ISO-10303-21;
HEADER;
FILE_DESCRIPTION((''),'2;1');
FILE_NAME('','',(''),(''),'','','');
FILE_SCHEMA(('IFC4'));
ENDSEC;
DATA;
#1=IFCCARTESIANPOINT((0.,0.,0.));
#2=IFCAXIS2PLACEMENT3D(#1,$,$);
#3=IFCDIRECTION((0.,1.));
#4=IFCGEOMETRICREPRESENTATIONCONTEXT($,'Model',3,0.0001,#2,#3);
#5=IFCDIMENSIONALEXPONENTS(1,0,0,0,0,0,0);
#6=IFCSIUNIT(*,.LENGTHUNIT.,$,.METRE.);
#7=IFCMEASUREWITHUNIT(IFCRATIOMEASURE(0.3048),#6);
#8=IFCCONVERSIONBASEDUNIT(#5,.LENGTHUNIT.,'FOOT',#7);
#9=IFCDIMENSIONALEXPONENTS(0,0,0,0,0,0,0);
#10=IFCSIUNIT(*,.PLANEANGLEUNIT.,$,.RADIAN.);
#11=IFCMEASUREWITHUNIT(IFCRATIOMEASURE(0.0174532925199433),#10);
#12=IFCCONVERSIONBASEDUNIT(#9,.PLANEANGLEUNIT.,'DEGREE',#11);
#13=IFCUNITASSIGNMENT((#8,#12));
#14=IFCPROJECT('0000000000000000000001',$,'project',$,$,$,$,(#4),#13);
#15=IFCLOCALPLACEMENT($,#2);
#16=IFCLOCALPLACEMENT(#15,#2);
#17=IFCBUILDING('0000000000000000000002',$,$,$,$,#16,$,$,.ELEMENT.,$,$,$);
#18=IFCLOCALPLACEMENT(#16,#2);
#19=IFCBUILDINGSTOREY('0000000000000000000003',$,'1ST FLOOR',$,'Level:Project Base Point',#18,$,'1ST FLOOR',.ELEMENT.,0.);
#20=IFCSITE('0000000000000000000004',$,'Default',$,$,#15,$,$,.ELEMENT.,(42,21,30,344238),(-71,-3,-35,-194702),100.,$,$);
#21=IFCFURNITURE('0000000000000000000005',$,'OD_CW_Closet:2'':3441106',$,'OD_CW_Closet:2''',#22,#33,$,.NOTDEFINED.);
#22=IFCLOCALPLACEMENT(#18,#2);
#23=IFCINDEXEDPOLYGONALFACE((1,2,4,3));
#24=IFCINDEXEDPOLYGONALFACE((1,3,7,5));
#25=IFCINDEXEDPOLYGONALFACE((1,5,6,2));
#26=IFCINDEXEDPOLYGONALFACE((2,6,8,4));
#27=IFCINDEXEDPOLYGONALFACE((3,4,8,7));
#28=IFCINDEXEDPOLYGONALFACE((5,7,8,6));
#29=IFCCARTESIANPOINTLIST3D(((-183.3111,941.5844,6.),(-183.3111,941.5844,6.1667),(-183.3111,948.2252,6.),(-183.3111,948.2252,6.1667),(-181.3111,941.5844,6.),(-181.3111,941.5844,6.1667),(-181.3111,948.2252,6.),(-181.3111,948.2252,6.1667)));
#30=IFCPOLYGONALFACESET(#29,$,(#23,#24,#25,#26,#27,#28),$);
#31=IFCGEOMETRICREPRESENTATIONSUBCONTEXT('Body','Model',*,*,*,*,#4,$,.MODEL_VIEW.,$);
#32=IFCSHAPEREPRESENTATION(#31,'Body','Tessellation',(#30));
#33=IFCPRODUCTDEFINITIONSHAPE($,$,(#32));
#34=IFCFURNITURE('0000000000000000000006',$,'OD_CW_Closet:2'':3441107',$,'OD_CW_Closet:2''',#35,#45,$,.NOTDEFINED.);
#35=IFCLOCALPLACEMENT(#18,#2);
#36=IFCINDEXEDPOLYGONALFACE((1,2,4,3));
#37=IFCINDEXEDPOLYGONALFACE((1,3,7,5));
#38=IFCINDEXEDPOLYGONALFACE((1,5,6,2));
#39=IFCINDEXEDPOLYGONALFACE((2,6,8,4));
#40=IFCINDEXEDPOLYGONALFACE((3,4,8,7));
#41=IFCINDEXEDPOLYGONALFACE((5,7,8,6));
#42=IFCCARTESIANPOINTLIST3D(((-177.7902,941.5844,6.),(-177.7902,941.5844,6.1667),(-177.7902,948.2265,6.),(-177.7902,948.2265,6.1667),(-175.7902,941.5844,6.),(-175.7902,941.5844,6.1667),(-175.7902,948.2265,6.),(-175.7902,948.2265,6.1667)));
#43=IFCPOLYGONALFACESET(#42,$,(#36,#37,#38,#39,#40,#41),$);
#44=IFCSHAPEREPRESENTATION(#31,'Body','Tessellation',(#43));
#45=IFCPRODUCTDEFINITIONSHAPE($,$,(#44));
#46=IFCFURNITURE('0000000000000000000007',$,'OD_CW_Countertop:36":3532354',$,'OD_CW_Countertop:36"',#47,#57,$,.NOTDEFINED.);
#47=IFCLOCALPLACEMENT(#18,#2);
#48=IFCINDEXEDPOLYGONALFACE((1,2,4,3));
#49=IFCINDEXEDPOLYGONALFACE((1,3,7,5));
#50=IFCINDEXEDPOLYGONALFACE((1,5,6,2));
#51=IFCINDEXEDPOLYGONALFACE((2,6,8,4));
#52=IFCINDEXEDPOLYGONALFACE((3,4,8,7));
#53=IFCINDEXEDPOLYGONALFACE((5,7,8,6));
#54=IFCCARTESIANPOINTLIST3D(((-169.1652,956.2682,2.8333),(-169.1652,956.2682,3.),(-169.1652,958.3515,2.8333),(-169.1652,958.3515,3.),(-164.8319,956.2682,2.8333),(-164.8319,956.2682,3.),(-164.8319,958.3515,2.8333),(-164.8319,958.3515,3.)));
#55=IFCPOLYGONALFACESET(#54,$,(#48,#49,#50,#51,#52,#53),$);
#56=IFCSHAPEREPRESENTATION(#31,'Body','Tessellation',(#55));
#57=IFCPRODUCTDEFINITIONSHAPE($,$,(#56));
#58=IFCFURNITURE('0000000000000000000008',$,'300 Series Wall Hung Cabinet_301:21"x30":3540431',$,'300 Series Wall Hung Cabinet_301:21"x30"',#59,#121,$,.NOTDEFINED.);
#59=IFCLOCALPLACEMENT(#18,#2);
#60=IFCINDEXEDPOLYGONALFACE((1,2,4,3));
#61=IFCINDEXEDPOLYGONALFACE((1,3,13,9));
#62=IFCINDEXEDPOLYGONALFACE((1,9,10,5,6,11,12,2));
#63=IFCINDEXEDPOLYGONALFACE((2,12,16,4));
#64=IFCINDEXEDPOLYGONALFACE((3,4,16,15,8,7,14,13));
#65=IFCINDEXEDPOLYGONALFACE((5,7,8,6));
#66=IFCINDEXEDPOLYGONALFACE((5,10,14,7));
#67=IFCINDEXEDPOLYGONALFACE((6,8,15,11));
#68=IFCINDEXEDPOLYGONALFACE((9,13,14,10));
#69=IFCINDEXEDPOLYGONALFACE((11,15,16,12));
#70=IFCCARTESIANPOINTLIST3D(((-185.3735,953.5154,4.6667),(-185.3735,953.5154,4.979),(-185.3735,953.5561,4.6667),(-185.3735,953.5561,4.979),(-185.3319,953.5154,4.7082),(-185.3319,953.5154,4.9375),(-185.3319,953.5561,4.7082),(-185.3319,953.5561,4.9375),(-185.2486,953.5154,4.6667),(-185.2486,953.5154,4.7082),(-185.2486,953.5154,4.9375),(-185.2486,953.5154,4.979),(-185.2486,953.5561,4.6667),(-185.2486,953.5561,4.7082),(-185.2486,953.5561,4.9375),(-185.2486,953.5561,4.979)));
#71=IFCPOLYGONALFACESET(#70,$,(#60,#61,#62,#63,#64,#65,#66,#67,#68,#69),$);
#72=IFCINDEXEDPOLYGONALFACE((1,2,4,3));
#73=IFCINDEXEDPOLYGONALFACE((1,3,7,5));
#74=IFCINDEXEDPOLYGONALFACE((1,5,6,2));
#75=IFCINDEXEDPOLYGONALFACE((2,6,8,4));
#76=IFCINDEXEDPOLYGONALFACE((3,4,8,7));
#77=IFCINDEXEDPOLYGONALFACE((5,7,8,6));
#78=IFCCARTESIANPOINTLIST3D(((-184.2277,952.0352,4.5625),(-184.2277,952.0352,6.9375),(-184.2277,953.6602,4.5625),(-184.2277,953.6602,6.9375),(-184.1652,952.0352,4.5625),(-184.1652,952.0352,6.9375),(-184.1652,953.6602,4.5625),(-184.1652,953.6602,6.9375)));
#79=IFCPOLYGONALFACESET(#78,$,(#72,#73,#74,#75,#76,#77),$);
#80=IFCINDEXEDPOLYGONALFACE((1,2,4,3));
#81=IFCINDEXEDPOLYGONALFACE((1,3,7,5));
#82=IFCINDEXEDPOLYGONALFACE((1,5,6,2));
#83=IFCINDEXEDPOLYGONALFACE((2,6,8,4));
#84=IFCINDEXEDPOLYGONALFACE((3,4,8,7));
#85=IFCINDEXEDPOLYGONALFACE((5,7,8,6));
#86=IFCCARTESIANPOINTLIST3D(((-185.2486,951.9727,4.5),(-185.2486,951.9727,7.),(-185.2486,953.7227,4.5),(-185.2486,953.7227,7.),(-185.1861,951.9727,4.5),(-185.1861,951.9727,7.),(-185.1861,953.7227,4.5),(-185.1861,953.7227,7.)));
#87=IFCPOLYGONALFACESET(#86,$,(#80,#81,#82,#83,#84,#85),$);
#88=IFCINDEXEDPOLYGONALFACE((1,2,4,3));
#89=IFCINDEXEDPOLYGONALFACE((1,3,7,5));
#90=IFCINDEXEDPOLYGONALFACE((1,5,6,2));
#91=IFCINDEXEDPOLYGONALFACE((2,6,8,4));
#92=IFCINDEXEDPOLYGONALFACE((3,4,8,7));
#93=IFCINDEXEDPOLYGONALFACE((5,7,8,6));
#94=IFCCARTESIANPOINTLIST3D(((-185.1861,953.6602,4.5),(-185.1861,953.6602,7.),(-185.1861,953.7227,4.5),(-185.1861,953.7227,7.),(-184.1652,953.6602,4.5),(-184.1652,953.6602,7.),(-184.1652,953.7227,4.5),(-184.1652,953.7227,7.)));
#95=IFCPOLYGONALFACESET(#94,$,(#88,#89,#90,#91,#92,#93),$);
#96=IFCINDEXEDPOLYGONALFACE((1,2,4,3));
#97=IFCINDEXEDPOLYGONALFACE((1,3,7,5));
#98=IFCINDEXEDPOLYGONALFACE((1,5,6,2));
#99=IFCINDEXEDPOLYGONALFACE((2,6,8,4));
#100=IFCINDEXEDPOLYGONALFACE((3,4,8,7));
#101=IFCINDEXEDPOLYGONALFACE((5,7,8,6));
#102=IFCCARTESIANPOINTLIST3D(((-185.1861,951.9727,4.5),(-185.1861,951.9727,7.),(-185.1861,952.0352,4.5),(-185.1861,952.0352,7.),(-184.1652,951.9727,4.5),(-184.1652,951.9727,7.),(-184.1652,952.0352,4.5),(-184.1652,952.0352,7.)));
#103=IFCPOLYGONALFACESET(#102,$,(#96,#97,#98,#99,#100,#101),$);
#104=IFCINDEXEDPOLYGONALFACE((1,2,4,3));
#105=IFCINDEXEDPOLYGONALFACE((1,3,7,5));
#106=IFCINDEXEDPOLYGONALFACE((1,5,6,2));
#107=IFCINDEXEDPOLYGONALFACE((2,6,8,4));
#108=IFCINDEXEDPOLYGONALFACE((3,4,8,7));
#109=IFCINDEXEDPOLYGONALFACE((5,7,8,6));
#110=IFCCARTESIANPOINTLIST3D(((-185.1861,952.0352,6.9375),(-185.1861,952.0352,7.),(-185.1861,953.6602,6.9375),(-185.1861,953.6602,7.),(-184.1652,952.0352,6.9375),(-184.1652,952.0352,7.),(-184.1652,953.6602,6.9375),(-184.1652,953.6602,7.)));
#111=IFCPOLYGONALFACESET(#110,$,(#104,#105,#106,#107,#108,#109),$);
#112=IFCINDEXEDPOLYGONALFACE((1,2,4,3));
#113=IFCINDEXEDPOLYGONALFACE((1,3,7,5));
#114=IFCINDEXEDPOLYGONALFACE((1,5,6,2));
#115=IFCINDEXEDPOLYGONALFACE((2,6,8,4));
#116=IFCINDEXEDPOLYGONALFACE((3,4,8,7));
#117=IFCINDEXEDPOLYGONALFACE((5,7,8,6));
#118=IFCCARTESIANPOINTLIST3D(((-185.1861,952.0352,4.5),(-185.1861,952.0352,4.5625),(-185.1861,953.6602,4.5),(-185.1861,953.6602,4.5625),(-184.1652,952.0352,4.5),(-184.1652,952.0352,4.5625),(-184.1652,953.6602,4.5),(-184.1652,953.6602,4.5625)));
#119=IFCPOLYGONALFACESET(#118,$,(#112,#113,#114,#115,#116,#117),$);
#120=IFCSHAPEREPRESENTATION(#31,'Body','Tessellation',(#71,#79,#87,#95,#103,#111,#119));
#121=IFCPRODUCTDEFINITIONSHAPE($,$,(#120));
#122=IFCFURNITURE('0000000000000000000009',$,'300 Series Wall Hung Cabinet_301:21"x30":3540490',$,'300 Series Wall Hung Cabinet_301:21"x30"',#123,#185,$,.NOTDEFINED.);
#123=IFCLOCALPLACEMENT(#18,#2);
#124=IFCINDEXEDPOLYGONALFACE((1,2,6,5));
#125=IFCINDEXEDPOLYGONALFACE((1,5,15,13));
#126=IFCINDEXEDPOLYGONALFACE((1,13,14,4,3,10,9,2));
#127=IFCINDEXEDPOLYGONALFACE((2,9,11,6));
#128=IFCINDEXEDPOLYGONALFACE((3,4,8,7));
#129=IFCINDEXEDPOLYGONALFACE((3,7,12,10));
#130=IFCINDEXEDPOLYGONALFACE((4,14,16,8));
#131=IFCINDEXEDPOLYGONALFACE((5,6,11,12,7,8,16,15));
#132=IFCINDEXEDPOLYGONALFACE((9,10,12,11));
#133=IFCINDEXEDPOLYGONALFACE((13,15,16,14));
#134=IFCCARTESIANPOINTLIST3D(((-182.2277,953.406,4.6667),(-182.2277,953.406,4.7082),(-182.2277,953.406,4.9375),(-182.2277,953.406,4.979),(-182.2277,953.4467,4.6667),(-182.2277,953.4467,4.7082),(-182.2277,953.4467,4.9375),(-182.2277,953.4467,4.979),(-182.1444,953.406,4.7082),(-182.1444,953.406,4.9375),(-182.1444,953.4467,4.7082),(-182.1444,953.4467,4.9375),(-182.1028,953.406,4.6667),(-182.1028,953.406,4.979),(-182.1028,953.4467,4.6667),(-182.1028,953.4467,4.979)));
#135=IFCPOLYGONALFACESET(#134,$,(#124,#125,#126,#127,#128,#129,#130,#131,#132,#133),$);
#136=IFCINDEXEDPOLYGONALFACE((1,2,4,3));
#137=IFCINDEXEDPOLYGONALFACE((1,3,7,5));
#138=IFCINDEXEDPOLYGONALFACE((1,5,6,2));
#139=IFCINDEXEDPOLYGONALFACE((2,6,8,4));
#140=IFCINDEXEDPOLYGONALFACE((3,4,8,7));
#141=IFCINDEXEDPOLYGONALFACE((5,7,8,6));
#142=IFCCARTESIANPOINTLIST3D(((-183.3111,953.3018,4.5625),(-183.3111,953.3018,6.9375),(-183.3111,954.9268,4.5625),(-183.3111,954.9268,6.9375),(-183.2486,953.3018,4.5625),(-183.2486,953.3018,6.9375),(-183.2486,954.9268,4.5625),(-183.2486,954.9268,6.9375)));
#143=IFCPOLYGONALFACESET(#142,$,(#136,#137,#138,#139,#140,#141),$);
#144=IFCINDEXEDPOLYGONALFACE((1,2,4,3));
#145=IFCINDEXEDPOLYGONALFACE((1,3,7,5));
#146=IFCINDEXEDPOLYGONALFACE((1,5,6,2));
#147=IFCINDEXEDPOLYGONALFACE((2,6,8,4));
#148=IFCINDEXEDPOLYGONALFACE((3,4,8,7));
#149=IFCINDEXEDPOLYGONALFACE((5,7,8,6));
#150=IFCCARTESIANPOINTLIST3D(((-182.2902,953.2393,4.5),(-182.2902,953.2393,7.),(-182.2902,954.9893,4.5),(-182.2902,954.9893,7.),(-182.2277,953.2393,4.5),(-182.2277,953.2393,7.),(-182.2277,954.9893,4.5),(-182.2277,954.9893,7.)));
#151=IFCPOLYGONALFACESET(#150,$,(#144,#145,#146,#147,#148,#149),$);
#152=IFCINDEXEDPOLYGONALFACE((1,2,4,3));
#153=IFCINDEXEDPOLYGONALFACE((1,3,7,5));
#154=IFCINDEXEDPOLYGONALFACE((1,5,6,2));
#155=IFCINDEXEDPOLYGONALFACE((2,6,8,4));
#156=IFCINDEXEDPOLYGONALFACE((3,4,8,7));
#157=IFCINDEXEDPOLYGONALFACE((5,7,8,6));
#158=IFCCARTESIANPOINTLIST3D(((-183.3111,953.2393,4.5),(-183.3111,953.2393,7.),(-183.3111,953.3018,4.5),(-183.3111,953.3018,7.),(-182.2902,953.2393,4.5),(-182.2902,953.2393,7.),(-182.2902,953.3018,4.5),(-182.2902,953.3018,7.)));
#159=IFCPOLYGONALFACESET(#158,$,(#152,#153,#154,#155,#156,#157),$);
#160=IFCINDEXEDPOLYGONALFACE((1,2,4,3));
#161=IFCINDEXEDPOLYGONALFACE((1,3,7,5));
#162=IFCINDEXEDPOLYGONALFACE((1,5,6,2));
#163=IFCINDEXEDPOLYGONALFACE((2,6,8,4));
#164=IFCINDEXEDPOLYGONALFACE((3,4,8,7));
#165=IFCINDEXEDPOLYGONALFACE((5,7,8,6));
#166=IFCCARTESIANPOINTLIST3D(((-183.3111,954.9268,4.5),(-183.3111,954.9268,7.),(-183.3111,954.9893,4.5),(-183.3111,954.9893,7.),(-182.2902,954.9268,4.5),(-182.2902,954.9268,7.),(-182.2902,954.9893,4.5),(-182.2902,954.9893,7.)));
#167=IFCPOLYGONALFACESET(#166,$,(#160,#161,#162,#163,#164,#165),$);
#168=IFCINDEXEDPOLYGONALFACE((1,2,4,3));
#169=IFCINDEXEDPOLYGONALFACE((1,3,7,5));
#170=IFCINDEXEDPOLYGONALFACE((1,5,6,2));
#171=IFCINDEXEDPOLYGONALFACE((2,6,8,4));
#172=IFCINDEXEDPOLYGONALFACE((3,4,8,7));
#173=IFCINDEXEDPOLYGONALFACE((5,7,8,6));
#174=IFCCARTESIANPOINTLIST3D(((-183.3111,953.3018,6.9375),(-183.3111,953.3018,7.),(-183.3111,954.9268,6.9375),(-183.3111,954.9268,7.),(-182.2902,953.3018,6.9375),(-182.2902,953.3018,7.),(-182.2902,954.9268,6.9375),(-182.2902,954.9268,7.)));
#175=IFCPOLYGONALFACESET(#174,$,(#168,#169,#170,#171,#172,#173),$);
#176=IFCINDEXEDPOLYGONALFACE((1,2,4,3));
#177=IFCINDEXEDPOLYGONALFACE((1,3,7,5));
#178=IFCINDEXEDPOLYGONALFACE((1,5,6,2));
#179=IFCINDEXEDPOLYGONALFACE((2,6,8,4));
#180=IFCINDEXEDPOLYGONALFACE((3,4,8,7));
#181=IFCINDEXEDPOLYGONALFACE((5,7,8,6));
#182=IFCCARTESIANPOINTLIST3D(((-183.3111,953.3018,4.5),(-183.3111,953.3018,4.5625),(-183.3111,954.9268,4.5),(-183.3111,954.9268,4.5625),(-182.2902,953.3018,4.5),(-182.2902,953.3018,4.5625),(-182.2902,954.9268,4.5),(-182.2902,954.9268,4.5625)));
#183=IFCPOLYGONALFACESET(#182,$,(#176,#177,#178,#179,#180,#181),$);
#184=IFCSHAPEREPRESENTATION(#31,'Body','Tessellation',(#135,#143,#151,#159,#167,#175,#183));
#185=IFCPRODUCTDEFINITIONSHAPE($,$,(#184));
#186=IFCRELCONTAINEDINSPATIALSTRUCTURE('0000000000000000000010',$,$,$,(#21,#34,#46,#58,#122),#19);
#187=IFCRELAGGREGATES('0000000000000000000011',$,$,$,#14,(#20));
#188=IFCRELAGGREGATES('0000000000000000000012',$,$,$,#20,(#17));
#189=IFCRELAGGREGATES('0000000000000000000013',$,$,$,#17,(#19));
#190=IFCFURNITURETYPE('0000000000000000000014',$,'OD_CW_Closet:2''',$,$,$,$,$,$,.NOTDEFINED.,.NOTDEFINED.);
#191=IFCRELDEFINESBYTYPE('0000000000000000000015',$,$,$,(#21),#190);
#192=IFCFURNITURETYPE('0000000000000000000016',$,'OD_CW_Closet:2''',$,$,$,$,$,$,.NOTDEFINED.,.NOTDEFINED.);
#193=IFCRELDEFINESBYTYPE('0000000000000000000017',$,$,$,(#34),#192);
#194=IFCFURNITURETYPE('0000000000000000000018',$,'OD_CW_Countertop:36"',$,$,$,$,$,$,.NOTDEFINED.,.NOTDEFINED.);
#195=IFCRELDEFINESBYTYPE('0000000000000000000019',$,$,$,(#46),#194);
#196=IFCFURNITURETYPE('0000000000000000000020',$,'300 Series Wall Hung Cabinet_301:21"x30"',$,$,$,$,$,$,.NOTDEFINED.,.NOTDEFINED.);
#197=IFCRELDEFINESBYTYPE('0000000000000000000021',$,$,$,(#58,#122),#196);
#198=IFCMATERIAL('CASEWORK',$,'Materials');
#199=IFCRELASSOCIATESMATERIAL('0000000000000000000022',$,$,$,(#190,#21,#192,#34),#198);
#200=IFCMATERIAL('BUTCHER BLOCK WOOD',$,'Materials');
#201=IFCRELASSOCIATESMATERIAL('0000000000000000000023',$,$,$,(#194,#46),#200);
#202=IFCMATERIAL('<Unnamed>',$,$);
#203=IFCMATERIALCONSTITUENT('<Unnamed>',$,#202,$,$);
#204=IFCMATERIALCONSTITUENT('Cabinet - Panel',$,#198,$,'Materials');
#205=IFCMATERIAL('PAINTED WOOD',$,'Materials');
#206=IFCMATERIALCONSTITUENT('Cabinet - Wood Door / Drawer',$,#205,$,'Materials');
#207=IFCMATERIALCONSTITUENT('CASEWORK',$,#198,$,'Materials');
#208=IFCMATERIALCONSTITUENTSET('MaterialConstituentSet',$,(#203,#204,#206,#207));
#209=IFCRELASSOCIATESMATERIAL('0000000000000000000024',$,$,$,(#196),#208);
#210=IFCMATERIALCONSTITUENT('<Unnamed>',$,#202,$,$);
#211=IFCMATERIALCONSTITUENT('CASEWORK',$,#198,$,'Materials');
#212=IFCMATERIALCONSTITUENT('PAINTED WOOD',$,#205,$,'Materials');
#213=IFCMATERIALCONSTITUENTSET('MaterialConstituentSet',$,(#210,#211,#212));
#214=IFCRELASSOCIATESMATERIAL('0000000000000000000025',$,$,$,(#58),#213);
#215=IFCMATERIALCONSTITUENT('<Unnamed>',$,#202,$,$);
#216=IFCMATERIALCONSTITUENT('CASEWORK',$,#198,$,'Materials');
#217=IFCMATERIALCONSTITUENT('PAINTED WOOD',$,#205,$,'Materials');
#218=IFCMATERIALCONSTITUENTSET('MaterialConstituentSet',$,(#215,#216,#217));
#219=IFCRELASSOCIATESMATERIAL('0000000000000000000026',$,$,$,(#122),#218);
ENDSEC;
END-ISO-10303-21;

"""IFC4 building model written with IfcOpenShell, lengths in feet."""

from ifc_helpers import new_model, entity, si_unit, converted_unit, direction, frame, frame_2d, origin, origin_2d_with_axis, place, context, subcontext, project, spatial, polyline, rectangle, outline, extrude, source, transform, mapped, material, constituent, constituent_set, type_object, type_shapes, element, save


model = new_model("IFC4")

# Units and contexts
model_context = context("Model", 3, precision=0.0001, world=origin(), true_north=direction((0.0, 1.0)))
body_context = subcontext(model_context, "Body", "Model", "MODEL_VIEW")
ifc_project = project(units=[converted_unit("LENGTHUNIT", "FOOT", entity("IfcRatioMeasure", 0.3048), si_unit("LENGTHUNIT", "METRE"), dimensions=[1, 0, 0, 0, 0, 0, 0]), converted_unit("PLANEANGLEUNIT", "DEGREE", entity("IfcRatioMeasure", 0.0174532925199433), si_unit("PLANEANGLEUNIT", "RADIAN"), dimensions=[0, 0, 0, 0, 0, 0, 0])], contexts=[model_context])

# Site, building, storey
site_placement = place(None, origin())
site = spatial("IfcSite", under=ifc_project, at=site_placement, Name="Default", CompositionType="ELEMENT", RefLatitude=(42, 21, 30, 344238), RefLongitude=(-71, -3, -35, -194702), RefElevation=100.0)
building_placement = place(site_placement, origin())
building = spatial("IfcBuilding", under=site, at=building_placement, CompositionType="ELEMENT")
storey_placement = place(building_placement, origin())
storey = spatial("IfcBuildingStorey", under=building, at=storey_placement, Name="1ST FLOOR", ObjectType="Level:Project Base Point", LongName="1ST FLOOR", CompositionType="ELEMENT", Elevation=0.0)

# Shared definitions
ifc_material_1 = material(Name="CASEWORK", Category="Materials")

# Furniture
ifc_material_2 = material(Name="PAINTED WOOD", Category="Materials")
furniture_type_1 = type_object("IfcFurnitureType", Name="OD_CW_Closet:2'", AssemblyPlace="NOTDEFINED", PredefinedType="NOTDEFINED", material=ifc_material_1)
shared_shape_1 = source(origin(), body_context, "Body", "SweptSolid", [
    extrude(rectangle(XDim=6.6407, YDim=2.0, at=origin_2d_with_axis()), frame((3.3204, 1.0, 0.0)), (0.0, 0.0, 1.0), 0.1667),
])
type_shapes(furniture_type_1, [shared_shape_1])
furniture_1_placement = place(storey_placement, frame((-183.3111, 948.2252, 6.0), z_axis=(0.0, 0.0, 1.0), x_axis=(0.0, -1.0, 0.0)))
element("IfcFurniture", 1, at=furniture_1_placement, inside=storey, type_object=furniture_type_1, material=ifc_material_1, Name="OD_CW_Closet:2':3441106", ObjectType="OD_CW_Closet:2'", PredefinedType="NOTDEFINED", context=body_context, shape_type="MappedRepresentation", body=[
    mapped(shared_shape_1, transform((0.0, 0.0, 0.0), scale=1.0)),
])
furniture_type_2 = type_object("IfcFurnitureType", Name="OD_CW_Closet:2'", AssemblyPlace="NOTDEFINED", PredefinedType="NOTDEFINED", material=ifc_material_1)
shared_shape_2 = source(origin(), body_context, "Body", "SweptSolid", [
    extrude(rectangle(XDim=2.0, YDim=6.6421, at=origin_2d_with_axis()), frame((3.3211, 1.0, 0.0), z_axis=(0.0, 0.0, 1.0), x_axis=(0.0, -1.0, 0.0)), (0.0, 0.0, 1.0), 0.1667),
])
type_shapes(furniture_type_2, [shared_shape_2])
furniture_2_placement = place(storey_placement, frame((-177.7902, 948.2265, 6.0), z_axis=(0.0, 0.0, 1.0), x_axis=(0.0, -1.0, 0.0)))
element("IfcFurniture", 2, at=furniture_2_placement, inside=storey, type_object=furniture_type_2, material=ifc_material_1, Name="OD_CW_Closet:2':3441107", ObjectType="OD_CW_Closet:2'", PredefinedType="NOTDEFINED", context=body_context, shape_type="MappedRepresentation", body=[
    mapped(shared_shape_2, transform((0.0, 0.0, 0.0), scale=1.0)),
])

# Furniture
ifc_material_3 = material(Name="BUTCHER BLOCK WOOD", Category="Materials")
furniture_type_3 = type_object("IfcFurnitureType", Name="OD_CW_Countertop:36\"", AssemblyPlace="NOTDEFINED", PredefinedType="NOTDEFINED", material=ifc_material_3)
shared_shape_3 = source(origin(), body_context, "Body", "SweptSolid", [
    extrude(rectangle(XDim=2.0833, YDim=4.3333, at=frame_2d((0.0, 0.0), x_axis=(1.0, 0.0))), frame((2.1667, 1.0417, 0.0), z_axis=(0.0, 0.0, 1.0), x_axis=(0.0, -1.0, 0.0)), (0.0, 0.0, 1.0), 0.1667),
])
type_shapes(furniture_type_3, [shared_shape_3])
furniture_3_placement = place(storey_placement, frame((-169.1652, 956.2682, 2.8333)))
element("IfcFurniture", 3, at=furniture_3_placement, inside=storey, type_object=furniture_type_3, material=ifc_material_3, Name="OD_CW_Countertop:36\":3532354", ObjectType="OD_CW_Countertop:36\"", PredefinedType="NOTDEFINED", context=body_context, shape_type="MappedRepresentation", body=[
    mapped(shared_shape_3, transform((0.0, 0.0, 0.0), scale=1.0)),
])
ifc_material_4 = material(Name="<Unnamed>")
ifc_constituent_1 = constituent(ifc_material_4, Name="<Unnamed>")
ifc_constituent_2 = constituent(ifc_material_1, Name="CASEWORK", Category="Materials")
ifc_constituent_3 = constituent(ifc_material_2, Name="PAINTED WOOD", Category="Materials")
ifc_constituent_set_1 = constituent_set(constituents=[ifc_constituent_1, ifc_constituent_2, ifc_constituent_3], Name="MaterialConstituentSet")
ifc_constituent_4 = constituent(ifc_material_4, Name="<Unnamed>")
ifc_constituent_5 = constituent(ifc_material_1, Name="Cabinet - Panel", Category="Materials")
ifc_constituent_6 = constituent(ifc_material_2, Name="Cabinet - Wood Door / Drawer", Category="Materials")
ifc_constituent_7 = constituent(ifc_material_1, Name="CASEWORK", Category="Materials")
ifc_constituent_set_2 = constituent_set(constituents=[ifc_constituent_4, ifc_constituent_5, ifc_constituent_6, ifc_constituent_7], Name="MaterialConstituentSet")
furniture_type_4 = type_object("IfcFurnitureType", Name="300 Series Wall Hung Cabinet_301:21\"x30\"", AssemblyPlace="NOTDEFINED", PredefinedType="NOTDEFINED", material=ifc_constituent_set_2)
shared_shape_4 = source(origin(), body_context, "Body", "SweptSolid", [
    extrude(outline(polyline([(0.1146, -0.0521), (0.1562, -0.0521), (0.1562, 0.0729), (-0.1562, 0.0729), (-0.1562, -0.0521), (-0.1146, -0.0521), (-0.1146, 0.0313), (0.1146, 0.0313), (0.1146, -0.0521)])), frame((0.1667, 0.0729, 0.3229), z_axis=(1.0, 0.0, 0.0), x_axis=(0.0, 0.0, 1.0)), (0.0, 0.0, 1.0), 0.0407),
    extrude(rectangle(XDim=1.625, YDim=0.0625, at=origin_2d_with_axis()), frame((0.875, 1.177, 0.0625), z_axis=(0.0, 0.0, 1.0), x_axis=(-1.0, 0.0, 0.0)), (0.0, 0.0, 1.0), 2.375),
    extrude(rectangle(XDim=1.75, YDim=0.0625, at=origin_2d_with_axis()), frame((0.875, 0.1562, 0.0), z_axis=(0.0, 0.0, 1.0), x_axis=(-1.0, 0.0, 0.0)), (0.0, 0.0, 1.0), 2.5),
    extrude(rectangle(XDim=1.0208, YDim=0.0625, at=frame_2d((0.0, 0.0), x_axis=(1.0, 0.0))), frame((0.0313, 0.6979, 0.0), z_axis=(0.0, 0.0, 1.0), x_axis=(0.0, -1.0, 0.0)), (0.0, 0.0, 1.0), 2.5),
    extrude(rectangle(XDim=1.0208, YDim=0.0625, at=frame_2d((0.0, 0.0), x_axis=(1.0, 0.0))), frame((1.7188, 0.6979, 0.0), z_axis=(0.0, 0.0, 1.0), x_axis=(0.0, -1.0, 0.0)), (0.0, 0.0, 1.0), 2.5),
    extrude(rectangle(XDim=1.0208, YDim=1.625, at=origin_2d_with_axis()), frame((0.875, 0.6979, 2.4375), z_axis=(0.0, 0.0, 1.0), x_axis=(0.0, 1.0, 0.0)), (0.0, 0.0, 1.0), 0.0625),
    extrude(rectangle(XDim=1.0208, YDim=1.625, at=origin_2d_with_axis()), frame((0.875, 0.6979, 0.0), z_axis=(0.0, 0.0, 1.0), x_axis=(0.0, 1.0, 0.0)), (0.0, 0.0, 1.0), 0.0625),
])
type_shapes(furniture_type_4, [shared_shape_4])
furniture_4_placement = place(storey_placement, frame((-185.3735, 953.7227, 4.5), z_axis=(0.0, 0.0, 1.0), x_axis=(0.0, -1.0, 0.0)))
element("IfcFurniture", 4, at=furniture_4_placement, inside=storey, type_object=furniture_type_4, material=ifc_constituent_set_1, Name="300 Series Wall Hung Cabinet_301:21\"x30\":3540431", ObjectType="300 Series Wall Hung Cabinet_301:21\"x30\"", PredefinedType="NOTDEFINED", context=body_context, shape_type="MappedRepresentation", body=[
    mapped(shared_shape_4, transform((0.0, 0.0, 0.0), scale=1.0)),
])
ifc_constituent_8 = constituent(ifc_material_4, Name="<Unnamed>")
ifc_constituent_9 = constituent(ifc_material_1, Name="CASEWORK", Category="Materials")
ifc_constituent_10 = constituent(ifc_material_2, Name="PAINTED WOOD", Category="Materials")
ifc_constituent_set_3 = constituent_set(constituents=[ifc_constituent_8, ifc_constituent_9, ifc_constituent_10], Name="MaterialConstituentSet")
furniture_5_placement = place(storey_placement, frame((-182.1028, 953.2393, 4.5), z_axis=(0.0, 0.0, 1.0), x_axis=(0.0, 1.0, 0.0)))
element("IfcFurniture", 5, at=furniture_5_placement, inside=storey, type_object=furniture_type_4, material=ifc_constituent_set_3, Name="300 Series Wall Hung Cabinet_301:21\"x30\":3540490", ObjectType="300 Series Wall Hung Cabinet_301:21\"x30\"", PredefinedType="NOTDEFINED", context=body_context, shape_type="MappedRepresentation", body=[
    mapped(shared_shape_4, transform((0.0, 0.0, 0.0), scale=1.0)),
])

save(model, "model.ifc")
